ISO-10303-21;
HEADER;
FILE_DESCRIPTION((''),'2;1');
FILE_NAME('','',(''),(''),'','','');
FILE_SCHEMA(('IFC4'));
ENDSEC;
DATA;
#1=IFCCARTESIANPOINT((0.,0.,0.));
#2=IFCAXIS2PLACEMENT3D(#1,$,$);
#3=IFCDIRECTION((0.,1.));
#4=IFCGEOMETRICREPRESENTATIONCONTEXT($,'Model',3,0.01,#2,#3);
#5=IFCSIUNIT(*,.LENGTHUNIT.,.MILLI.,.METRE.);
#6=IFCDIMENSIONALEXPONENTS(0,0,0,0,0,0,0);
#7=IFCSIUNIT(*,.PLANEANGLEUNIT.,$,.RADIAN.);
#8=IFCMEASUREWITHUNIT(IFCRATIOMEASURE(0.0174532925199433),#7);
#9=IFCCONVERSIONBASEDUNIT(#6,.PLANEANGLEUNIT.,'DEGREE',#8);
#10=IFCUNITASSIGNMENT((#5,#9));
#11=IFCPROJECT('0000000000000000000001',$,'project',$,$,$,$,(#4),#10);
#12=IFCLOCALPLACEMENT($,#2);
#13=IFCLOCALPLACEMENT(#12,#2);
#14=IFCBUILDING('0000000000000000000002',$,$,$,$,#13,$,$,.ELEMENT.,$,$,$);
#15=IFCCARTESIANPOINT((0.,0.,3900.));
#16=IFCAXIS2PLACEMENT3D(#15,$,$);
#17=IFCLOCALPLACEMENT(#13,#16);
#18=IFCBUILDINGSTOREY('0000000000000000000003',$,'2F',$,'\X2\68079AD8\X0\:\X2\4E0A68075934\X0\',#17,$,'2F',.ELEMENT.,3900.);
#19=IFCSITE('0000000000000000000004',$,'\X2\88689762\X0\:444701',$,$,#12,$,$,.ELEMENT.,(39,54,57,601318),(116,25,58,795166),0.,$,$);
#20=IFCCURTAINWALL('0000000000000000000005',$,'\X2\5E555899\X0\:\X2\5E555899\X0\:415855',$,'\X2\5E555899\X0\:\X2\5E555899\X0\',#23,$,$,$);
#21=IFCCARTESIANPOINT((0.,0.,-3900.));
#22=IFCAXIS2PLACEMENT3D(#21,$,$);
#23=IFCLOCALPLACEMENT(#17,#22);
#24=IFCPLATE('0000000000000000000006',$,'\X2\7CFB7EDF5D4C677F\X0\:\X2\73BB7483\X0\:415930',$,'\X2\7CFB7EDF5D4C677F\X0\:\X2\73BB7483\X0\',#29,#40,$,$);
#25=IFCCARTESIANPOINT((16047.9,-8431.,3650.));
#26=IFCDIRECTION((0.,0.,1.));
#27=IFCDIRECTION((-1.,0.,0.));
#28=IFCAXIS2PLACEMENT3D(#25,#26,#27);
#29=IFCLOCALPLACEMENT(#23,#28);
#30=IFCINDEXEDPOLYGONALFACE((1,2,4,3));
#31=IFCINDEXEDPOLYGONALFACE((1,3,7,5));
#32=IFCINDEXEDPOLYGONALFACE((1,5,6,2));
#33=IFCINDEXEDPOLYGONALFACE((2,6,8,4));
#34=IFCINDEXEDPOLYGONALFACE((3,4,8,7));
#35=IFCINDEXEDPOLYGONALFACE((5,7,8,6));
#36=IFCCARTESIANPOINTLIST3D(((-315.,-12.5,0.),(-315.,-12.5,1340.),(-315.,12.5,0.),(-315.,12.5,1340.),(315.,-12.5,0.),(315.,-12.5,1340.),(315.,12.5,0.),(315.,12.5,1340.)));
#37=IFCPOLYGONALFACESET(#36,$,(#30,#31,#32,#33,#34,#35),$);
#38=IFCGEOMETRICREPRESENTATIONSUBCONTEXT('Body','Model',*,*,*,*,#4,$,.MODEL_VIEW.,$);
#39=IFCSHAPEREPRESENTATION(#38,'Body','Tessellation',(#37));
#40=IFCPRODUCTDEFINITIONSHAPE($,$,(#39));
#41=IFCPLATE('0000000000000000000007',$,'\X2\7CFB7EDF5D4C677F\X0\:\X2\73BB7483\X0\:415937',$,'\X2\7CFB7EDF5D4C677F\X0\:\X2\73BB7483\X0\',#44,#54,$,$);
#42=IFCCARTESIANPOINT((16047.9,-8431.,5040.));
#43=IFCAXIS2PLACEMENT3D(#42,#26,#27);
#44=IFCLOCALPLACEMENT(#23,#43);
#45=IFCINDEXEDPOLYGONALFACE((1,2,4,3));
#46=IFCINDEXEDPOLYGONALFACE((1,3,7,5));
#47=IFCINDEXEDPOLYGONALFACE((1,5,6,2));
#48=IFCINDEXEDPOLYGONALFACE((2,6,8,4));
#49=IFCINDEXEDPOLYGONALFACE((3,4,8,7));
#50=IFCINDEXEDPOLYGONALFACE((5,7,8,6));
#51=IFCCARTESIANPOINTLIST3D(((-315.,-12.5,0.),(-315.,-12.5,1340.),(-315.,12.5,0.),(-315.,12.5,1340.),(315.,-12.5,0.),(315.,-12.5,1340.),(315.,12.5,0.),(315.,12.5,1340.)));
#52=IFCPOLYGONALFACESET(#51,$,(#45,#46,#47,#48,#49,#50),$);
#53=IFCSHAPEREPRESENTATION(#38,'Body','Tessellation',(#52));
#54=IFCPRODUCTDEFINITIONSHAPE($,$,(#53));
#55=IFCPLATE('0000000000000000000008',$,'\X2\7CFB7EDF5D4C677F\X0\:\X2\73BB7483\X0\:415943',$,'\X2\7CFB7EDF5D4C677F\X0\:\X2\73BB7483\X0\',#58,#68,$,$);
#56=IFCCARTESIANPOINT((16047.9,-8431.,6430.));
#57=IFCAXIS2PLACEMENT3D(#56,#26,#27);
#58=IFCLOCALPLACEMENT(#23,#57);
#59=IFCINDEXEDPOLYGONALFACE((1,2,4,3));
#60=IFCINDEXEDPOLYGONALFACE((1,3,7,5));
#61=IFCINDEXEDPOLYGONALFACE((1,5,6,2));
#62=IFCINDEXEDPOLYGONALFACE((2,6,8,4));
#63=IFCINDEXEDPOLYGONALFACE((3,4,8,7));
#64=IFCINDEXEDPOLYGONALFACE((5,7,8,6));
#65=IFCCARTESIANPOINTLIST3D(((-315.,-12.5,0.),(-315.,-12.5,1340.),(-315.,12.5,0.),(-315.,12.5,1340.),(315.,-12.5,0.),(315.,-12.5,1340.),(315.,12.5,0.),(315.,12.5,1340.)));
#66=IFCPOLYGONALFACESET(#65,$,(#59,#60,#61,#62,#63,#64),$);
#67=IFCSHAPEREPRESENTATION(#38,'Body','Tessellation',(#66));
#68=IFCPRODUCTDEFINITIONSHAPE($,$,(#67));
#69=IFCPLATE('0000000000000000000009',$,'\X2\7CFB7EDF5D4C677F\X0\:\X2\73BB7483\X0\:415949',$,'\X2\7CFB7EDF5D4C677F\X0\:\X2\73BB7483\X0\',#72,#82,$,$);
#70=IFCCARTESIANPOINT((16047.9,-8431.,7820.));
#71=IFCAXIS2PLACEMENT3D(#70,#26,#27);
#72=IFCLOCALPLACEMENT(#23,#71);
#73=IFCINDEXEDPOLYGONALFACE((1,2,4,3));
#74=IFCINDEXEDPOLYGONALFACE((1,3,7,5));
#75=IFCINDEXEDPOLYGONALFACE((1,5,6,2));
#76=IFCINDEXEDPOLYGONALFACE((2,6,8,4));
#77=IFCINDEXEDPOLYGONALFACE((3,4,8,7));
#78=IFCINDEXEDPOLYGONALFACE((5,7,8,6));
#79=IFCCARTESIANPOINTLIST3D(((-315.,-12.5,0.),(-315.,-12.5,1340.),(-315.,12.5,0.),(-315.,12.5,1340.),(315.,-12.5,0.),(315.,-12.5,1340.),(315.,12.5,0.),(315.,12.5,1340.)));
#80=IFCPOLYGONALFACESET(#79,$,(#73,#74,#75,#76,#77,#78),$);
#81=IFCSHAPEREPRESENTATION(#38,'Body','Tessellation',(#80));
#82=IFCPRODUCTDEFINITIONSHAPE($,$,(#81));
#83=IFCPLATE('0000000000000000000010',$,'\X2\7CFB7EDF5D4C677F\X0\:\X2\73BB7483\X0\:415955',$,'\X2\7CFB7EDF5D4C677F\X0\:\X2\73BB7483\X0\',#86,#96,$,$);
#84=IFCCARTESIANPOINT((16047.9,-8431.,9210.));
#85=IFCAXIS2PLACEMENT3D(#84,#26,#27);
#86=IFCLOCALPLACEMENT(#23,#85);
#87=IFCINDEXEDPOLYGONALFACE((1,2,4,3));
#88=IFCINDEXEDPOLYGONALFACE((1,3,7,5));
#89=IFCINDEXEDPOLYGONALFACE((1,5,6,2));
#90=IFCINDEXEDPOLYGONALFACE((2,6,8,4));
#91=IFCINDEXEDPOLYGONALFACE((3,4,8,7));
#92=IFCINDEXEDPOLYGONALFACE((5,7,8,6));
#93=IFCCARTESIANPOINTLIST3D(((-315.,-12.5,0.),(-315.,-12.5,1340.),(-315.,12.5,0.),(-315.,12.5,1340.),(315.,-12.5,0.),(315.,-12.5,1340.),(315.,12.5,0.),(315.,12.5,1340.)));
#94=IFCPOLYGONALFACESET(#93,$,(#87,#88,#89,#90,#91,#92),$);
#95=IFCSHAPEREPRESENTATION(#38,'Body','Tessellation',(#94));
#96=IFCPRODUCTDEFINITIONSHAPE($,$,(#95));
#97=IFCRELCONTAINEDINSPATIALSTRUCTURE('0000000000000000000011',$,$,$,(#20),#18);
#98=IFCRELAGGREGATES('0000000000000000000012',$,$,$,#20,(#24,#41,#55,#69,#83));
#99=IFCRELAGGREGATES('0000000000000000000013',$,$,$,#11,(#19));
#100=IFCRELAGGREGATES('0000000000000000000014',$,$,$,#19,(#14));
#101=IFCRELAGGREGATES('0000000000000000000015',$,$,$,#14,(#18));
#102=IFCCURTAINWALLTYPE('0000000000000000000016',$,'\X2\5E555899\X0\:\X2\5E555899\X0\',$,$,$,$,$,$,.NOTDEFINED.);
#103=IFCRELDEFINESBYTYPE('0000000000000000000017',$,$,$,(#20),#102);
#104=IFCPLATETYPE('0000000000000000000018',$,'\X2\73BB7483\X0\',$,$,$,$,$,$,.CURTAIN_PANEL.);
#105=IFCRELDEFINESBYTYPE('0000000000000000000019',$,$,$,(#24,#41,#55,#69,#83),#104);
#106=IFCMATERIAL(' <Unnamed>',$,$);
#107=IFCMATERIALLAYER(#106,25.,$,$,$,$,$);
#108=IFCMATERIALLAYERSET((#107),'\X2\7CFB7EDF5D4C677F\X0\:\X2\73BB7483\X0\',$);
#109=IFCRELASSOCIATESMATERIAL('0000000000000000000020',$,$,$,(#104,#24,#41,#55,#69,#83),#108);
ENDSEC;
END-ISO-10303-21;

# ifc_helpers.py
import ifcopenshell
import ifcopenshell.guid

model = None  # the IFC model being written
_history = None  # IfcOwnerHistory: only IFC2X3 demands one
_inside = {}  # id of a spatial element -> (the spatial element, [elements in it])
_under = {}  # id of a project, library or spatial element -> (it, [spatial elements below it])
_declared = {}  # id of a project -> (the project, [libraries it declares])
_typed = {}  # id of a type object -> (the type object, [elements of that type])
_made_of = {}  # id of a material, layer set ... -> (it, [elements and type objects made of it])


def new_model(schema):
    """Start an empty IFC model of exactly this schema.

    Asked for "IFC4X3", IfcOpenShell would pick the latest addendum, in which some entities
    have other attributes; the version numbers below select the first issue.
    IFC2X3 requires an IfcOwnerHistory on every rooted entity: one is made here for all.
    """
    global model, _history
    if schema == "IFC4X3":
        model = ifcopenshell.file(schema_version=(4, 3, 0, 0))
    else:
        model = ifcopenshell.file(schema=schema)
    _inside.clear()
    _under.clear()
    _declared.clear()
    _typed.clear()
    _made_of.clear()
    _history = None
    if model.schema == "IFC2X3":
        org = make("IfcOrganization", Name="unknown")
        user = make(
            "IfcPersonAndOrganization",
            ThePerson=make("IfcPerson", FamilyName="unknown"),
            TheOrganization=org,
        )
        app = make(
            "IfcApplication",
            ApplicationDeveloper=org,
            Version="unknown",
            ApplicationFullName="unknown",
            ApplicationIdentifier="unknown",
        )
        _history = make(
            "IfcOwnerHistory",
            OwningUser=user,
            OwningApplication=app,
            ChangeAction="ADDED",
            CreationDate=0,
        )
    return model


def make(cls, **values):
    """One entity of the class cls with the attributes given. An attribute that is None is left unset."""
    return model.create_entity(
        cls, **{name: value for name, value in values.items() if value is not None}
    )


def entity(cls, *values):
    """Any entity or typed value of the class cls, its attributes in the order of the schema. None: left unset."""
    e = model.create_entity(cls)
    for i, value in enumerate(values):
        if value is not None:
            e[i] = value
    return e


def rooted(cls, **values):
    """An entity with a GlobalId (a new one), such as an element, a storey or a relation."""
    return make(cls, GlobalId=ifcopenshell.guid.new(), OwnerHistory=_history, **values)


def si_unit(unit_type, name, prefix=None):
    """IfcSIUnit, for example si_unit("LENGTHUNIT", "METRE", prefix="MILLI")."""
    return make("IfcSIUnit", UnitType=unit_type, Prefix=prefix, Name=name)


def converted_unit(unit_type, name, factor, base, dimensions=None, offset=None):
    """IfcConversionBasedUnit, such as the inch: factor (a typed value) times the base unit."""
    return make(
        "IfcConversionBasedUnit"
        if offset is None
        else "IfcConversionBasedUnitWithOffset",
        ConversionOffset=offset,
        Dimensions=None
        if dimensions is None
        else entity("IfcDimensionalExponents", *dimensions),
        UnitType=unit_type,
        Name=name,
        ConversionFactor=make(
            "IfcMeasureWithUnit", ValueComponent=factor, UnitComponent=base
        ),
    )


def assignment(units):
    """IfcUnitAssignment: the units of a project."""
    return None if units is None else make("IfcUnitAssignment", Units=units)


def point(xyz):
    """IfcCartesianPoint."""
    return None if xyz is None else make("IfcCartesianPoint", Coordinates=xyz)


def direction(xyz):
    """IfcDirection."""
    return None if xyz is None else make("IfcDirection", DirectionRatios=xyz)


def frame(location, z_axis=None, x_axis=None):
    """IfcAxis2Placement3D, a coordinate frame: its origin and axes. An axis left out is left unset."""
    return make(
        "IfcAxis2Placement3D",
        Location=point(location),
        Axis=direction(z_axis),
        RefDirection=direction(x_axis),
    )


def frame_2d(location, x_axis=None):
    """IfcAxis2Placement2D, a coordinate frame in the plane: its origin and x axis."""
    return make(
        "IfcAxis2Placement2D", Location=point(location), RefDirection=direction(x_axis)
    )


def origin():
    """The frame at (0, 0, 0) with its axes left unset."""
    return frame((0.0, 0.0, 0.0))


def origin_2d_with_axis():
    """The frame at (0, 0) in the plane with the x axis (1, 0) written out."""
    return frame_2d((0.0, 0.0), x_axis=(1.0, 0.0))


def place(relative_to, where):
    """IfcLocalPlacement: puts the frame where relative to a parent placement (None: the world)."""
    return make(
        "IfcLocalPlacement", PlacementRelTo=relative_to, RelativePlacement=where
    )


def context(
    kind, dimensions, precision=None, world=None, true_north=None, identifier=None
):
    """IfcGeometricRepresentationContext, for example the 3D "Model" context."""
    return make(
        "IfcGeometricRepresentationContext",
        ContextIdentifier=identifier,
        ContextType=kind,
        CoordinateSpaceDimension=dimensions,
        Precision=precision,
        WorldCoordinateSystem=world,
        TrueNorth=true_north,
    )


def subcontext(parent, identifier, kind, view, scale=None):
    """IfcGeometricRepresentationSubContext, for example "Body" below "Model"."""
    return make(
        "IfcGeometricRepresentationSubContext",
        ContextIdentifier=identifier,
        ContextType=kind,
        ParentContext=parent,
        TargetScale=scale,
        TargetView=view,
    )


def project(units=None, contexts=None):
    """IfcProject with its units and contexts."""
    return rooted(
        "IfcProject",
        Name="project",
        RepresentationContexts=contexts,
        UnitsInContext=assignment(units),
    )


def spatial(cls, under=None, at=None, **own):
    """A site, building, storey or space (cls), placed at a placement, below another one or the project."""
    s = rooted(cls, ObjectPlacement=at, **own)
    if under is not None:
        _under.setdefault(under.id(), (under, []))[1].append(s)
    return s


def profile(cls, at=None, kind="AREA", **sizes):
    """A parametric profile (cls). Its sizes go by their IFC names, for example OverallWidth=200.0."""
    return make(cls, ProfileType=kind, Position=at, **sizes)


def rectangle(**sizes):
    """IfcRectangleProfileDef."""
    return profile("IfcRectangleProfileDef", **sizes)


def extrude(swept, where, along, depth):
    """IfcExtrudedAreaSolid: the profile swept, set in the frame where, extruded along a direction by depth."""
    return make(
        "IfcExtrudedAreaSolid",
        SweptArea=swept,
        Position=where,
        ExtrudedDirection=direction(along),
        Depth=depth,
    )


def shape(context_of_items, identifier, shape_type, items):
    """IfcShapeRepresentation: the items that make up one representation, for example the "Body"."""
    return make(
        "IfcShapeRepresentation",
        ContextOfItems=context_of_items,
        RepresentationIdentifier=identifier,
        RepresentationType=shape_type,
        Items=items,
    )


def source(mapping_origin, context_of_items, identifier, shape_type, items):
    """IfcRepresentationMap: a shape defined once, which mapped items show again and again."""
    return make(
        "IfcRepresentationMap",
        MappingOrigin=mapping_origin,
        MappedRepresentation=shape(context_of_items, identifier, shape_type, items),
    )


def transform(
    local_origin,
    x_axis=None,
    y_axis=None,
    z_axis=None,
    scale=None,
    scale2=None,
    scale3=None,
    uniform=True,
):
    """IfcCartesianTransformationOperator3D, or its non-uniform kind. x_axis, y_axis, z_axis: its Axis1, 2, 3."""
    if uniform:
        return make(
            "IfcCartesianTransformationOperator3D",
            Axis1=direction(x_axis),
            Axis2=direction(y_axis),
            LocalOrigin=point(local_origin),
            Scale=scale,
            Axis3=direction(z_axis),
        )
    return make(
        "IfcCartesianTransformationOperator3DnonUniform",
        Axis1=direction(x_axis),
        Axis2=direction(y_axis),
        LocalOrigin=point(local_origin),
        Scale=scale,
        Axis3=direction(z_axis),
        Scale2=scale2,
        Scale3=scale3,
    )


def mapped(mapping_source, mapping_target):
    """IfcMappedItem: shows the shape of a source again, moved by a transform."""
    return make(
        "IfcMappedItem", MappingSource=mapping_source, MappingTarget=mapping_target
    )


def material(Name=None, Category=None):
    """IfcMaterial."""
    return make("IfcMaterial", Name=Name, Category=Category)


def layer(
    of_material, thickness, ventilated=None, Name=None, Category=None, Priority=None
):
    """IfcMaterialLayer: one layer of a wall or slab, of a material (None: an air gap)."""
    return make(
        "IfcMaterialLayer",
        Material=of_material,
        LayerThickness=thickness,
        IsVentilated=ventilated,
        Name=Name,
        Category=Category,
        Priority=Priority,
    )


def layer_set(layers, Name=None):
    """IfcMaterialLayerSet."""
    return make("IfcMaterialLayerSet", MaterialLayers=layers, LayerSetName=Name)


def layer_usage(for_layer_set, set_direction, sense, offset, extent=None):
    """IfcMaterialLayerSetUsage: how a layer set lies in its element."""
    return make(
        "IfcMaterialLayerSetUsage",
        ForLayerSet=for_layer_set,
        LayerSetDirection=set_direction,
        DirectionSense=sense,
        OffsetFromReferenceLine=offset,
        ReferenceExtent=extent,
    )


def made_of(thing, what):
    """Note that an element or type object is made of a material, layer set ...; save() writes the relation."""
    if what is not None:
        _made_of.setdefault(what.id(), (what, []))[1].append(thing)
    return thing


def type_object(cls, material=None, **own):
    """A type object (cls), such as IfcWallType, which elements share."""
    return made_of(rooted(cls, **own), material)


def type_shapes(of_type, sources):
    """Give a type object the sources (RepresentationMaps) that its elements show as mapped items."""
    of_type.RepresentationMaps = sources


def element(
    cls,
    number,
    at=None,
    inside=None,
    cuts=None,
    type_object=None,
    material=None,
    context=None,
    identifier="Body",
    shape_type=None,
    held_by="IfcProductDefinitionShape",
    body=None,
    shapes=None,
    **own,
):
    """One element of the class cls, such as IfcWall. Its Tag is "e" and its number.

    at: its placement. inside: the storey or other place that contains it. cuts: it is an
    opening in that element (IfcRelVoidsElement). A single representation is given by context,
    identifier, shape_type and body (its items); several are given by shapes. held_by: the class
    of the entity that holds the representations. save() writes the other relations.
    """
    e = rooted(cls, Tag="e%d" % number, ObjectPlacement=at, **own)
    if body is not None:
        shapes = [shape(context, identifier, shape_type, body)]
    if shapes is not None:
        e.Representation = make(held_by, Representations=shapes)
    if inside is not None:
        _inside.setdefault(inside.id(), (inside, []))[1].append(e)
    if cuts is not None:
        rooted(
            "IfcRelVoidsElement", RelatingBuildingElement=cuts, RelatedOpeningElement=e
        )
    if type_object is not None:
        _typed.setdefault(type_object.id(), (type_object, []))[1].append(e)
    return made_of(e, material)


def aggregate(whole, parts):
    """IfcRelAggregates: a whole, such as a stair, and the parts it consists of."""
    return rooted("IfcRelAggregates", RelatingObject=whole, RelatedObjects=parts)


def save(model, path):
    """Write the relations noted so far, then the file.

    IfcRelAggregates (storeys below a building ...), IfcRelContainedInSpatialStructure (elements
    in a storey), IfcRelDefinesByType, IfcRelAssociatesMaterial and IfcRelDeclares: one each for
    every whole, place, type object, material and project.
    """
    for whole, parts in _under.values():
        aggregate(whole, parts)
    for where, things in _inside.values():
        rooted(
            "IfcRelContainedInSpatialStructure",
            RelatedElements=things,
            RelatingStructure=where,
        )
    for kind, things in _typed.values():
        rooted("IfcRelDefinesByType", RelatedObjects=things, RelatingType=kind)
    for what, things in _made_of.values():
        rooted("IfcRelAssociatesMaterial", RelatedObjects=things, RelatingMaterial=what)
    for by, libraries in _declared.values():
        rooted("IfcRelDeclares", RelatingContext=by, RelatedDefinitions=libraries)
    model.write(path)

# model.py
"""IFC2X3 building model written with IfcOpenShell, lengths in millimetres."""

from ifc_helpers import new_model, entity, si_unit, converted_unit, direction, frame, origin, origin_2d_with_axis, place, context, subcontext, project, spatial, rectangle, extrude, source, transform, mapped, material, layer, layer_set, layer_usage, type_object, type_shapes, element, aggregate, save


model = new_model("IFC2X3")

# Units and contexts
model_context = context("Model", 3, precision=0.01, world=origin(), true_north=direction((0.0, 1.0)))
body_context = subcontext(model_context, "Body", "Model", "MODEL_VIEW")
ifc_project = project(units=[si_unit("LENGTHUNIT", "METRE", prefix="MILLI"), converted_unit("PLANEANGLEUNIT", "DEGREE", entity("IfcRatioMeasure", 0.0174532925199433), si_unit("PLANEANGLEUNIT", "RADIAN"), dimensions=[0, 0, 0, 0, 0, 0, 0])], contexts=[model_context])

# Site, building, storey
site_placement = place(None, origin())
site = spatial("IfcSite", under=ifc_project, at=site_placement, Name="表面:444701", CompositionType="ELEMENT", RefLatitude=(39, 54, 57, 601318), RefLongitude=(116, 25, 58, 795166), RefElevation=0.0)
building_placement = place(site_placement, origin())
building = spatial("IfcBuilding", under=site, at=building_placement, CompositionType="ELEMENT")
storey_placement = place(building_placement, frame((0.0, 0.0, 3900.0)))
storey = spatial("IfcBuildingStorey", under=building, at=storey_placement, Name="2F", ObjectType="标高:上标头", LongName="2F", CompositionType="ELEMENT", Elevation=3900.0)

# Curtain wall
curtain_wall_type = type_object("IfcCurtainWallType", Name="幕墙:幕墙", PredefinedType="NOTDEFINED")
curtain_wall_1_placement = place(storey_placement, frame((0.0, 0.0, -3900.0)))
curtain_wall_1 = element("IfcCurtainWall", 1, at=curtain_wall_1_placement, inside=storey, type_object=curtain_wall_type, Name="幕墙:幕墙:415855", ObjectType="幕墙:幕墙")

# Plates
ifc_material_1 = material(Name=" <Unnamed>")
ifc_layer = layer(ifc_material_1, 25.0)
ifc_layer_set = layer_set([ifc_layer], Name="系统嵌板:玻璃")
ifc_layer_usage_1 = layer_usage(ifc_layer_set, "AXIS3", "POSITIVE", 0.0)
plate_type = type_object("IfcPlateType", Name="玻璃", PredefinedType="CURTAIN_PANEL", material=ifc_layer_set)
shared_shape_1 = source(origin(), body_context, "Body", "SweptSolid", [
    extrude(rectangle(XDim=25.0, YDim=630.0, at=origin_2d_with_axis()), frame((0.0, 0.0, 0.0), z_axis=(0.0, 0.0, 1.0), x_axis=(0.0, 1.0, 0.0)), (0.0, 0.0, 1.0), 1340.0),
])
type_shapes(plate_type, [shared_shape_1])
plate_1_placement = place(curtain_wall_1_placement, frame((16047.9, -8431.0, 3650.0), z_axis=(0.0, 0.0, 1.0), x_axis=(-1.0, 0.0, 0.0)))
plate_1 = element("IfcPlate", 2, at=plate_1_placement, type_object=plate_type, material=ifc_layer_usage_1, Name="系统嵌板:玻璃:415930", ObjectType="系统嵌板:玻璃", context=body_context, shape_type="MappedRepresentation", body=[
    mapped(shared_shape_1, transform((0.0, 0.0, 0.0), scale=1.0)),
])
ifc_layer_usage_2 = layer_usage(ifc_layer_set, "AXIS3", "POSITIVE", 0.0)
plate_2_placement = place(curtain_wall_1_placement, frame((16047.9, -8431.0, 5040.0), z_axis=(0.0, 0.0, 1.0), x_axis=(-1.0, 0.0, 0.0)))
plate_2 = element("IfcPlate", 3, at=plate_2_placement, type_object=plate_type, material=ifc_layer_usage_2, Name="系统嵌板:玻璃:415937", ObjectType="系统嵌板:玻璃", context=body_context, shape_type="MappedRepresentation", body=[
    mapped(shared_shape_1, transform((0.0, 0.0, 0.0), scale=1.0)),
])
ifc_layer_usage_3 = layer_usage(ifc_layer_set, "AXIS3", "POSITIVE", 0.0)
plate_3_placement = place(curtain_wall_1_placement, frame((16047.9, -8431.0, 6430.0), z_axis=(0.0, 0.0, 1.0), x_axis=(-1.0, 0.0, 0.0)))
plate_3 = element("IfcPlate", 4, at=plate_3_placement, type_object=plate_type, material=ifc_layer_usage_3, Name="系统嵌板:玻璃:415943", ObjectType="系统嵌板:玻璃", context=body_context, shape_type="MappedRepresentation", body=[
    mapped(shared_shape_1, transform((0.0, 0.0, 0.0), scale=1.0)),
])
ifc_layer_usage_4 = layer_usage(ifc_layer_set, "AXIS3", "POSITIVE", 0.0)
plate_4_placement = place(curtain_wall_1_placement, frame((16047.9, -8431.0, 7820.0), z_axis=(0.0, 0.0, 1.0), x_axis=(-1.0, 0.0, 0.0)))
plate_4 = element("IfcPlate", 5, at=plate_4_placement, type_object=plate_type, material=ifc_layer_usage_4, Name="系统嵌板:玻璃:415949", ObjectType="系统嵌板:玻璃", context=body_context, shape_type="MappedRepresentation", body=[
    mapped(shared_shape_1, transform((0.0, 0.0, 0.0), scale=1.0)),
])
ifc_layer_usage_5 = layer_usage(ifc_layer_set, "AXIS3", "POSITIVE", 0.0)
plate_5_placement = place(curtain_wall_1_placement, frame((16047.9, -8431.0, 9210.0), z_axis=(0.0, 0.0, 1.0), x_axis=(-1.0, 0.0, 0.0)))
plate_5 = element("IfcPlate", 6, at=plate_5_placement, type_object=plate_type, material=ifc_layer_usage_5, Name="系统嵌板:玻璃:415955", ObjectType="系统嵌板:玻璃", context=body_context, shape_type="MappedRepresentation", body=[
    mapped(shared_shape_1, transform((0.0, 0.0, 0.0), scale=1.0)),
])
aggregate(curtain_wall_1, [plate_1, plate_2, plate_3, plate_4, plate_5])

save(model, "model.ifc")
